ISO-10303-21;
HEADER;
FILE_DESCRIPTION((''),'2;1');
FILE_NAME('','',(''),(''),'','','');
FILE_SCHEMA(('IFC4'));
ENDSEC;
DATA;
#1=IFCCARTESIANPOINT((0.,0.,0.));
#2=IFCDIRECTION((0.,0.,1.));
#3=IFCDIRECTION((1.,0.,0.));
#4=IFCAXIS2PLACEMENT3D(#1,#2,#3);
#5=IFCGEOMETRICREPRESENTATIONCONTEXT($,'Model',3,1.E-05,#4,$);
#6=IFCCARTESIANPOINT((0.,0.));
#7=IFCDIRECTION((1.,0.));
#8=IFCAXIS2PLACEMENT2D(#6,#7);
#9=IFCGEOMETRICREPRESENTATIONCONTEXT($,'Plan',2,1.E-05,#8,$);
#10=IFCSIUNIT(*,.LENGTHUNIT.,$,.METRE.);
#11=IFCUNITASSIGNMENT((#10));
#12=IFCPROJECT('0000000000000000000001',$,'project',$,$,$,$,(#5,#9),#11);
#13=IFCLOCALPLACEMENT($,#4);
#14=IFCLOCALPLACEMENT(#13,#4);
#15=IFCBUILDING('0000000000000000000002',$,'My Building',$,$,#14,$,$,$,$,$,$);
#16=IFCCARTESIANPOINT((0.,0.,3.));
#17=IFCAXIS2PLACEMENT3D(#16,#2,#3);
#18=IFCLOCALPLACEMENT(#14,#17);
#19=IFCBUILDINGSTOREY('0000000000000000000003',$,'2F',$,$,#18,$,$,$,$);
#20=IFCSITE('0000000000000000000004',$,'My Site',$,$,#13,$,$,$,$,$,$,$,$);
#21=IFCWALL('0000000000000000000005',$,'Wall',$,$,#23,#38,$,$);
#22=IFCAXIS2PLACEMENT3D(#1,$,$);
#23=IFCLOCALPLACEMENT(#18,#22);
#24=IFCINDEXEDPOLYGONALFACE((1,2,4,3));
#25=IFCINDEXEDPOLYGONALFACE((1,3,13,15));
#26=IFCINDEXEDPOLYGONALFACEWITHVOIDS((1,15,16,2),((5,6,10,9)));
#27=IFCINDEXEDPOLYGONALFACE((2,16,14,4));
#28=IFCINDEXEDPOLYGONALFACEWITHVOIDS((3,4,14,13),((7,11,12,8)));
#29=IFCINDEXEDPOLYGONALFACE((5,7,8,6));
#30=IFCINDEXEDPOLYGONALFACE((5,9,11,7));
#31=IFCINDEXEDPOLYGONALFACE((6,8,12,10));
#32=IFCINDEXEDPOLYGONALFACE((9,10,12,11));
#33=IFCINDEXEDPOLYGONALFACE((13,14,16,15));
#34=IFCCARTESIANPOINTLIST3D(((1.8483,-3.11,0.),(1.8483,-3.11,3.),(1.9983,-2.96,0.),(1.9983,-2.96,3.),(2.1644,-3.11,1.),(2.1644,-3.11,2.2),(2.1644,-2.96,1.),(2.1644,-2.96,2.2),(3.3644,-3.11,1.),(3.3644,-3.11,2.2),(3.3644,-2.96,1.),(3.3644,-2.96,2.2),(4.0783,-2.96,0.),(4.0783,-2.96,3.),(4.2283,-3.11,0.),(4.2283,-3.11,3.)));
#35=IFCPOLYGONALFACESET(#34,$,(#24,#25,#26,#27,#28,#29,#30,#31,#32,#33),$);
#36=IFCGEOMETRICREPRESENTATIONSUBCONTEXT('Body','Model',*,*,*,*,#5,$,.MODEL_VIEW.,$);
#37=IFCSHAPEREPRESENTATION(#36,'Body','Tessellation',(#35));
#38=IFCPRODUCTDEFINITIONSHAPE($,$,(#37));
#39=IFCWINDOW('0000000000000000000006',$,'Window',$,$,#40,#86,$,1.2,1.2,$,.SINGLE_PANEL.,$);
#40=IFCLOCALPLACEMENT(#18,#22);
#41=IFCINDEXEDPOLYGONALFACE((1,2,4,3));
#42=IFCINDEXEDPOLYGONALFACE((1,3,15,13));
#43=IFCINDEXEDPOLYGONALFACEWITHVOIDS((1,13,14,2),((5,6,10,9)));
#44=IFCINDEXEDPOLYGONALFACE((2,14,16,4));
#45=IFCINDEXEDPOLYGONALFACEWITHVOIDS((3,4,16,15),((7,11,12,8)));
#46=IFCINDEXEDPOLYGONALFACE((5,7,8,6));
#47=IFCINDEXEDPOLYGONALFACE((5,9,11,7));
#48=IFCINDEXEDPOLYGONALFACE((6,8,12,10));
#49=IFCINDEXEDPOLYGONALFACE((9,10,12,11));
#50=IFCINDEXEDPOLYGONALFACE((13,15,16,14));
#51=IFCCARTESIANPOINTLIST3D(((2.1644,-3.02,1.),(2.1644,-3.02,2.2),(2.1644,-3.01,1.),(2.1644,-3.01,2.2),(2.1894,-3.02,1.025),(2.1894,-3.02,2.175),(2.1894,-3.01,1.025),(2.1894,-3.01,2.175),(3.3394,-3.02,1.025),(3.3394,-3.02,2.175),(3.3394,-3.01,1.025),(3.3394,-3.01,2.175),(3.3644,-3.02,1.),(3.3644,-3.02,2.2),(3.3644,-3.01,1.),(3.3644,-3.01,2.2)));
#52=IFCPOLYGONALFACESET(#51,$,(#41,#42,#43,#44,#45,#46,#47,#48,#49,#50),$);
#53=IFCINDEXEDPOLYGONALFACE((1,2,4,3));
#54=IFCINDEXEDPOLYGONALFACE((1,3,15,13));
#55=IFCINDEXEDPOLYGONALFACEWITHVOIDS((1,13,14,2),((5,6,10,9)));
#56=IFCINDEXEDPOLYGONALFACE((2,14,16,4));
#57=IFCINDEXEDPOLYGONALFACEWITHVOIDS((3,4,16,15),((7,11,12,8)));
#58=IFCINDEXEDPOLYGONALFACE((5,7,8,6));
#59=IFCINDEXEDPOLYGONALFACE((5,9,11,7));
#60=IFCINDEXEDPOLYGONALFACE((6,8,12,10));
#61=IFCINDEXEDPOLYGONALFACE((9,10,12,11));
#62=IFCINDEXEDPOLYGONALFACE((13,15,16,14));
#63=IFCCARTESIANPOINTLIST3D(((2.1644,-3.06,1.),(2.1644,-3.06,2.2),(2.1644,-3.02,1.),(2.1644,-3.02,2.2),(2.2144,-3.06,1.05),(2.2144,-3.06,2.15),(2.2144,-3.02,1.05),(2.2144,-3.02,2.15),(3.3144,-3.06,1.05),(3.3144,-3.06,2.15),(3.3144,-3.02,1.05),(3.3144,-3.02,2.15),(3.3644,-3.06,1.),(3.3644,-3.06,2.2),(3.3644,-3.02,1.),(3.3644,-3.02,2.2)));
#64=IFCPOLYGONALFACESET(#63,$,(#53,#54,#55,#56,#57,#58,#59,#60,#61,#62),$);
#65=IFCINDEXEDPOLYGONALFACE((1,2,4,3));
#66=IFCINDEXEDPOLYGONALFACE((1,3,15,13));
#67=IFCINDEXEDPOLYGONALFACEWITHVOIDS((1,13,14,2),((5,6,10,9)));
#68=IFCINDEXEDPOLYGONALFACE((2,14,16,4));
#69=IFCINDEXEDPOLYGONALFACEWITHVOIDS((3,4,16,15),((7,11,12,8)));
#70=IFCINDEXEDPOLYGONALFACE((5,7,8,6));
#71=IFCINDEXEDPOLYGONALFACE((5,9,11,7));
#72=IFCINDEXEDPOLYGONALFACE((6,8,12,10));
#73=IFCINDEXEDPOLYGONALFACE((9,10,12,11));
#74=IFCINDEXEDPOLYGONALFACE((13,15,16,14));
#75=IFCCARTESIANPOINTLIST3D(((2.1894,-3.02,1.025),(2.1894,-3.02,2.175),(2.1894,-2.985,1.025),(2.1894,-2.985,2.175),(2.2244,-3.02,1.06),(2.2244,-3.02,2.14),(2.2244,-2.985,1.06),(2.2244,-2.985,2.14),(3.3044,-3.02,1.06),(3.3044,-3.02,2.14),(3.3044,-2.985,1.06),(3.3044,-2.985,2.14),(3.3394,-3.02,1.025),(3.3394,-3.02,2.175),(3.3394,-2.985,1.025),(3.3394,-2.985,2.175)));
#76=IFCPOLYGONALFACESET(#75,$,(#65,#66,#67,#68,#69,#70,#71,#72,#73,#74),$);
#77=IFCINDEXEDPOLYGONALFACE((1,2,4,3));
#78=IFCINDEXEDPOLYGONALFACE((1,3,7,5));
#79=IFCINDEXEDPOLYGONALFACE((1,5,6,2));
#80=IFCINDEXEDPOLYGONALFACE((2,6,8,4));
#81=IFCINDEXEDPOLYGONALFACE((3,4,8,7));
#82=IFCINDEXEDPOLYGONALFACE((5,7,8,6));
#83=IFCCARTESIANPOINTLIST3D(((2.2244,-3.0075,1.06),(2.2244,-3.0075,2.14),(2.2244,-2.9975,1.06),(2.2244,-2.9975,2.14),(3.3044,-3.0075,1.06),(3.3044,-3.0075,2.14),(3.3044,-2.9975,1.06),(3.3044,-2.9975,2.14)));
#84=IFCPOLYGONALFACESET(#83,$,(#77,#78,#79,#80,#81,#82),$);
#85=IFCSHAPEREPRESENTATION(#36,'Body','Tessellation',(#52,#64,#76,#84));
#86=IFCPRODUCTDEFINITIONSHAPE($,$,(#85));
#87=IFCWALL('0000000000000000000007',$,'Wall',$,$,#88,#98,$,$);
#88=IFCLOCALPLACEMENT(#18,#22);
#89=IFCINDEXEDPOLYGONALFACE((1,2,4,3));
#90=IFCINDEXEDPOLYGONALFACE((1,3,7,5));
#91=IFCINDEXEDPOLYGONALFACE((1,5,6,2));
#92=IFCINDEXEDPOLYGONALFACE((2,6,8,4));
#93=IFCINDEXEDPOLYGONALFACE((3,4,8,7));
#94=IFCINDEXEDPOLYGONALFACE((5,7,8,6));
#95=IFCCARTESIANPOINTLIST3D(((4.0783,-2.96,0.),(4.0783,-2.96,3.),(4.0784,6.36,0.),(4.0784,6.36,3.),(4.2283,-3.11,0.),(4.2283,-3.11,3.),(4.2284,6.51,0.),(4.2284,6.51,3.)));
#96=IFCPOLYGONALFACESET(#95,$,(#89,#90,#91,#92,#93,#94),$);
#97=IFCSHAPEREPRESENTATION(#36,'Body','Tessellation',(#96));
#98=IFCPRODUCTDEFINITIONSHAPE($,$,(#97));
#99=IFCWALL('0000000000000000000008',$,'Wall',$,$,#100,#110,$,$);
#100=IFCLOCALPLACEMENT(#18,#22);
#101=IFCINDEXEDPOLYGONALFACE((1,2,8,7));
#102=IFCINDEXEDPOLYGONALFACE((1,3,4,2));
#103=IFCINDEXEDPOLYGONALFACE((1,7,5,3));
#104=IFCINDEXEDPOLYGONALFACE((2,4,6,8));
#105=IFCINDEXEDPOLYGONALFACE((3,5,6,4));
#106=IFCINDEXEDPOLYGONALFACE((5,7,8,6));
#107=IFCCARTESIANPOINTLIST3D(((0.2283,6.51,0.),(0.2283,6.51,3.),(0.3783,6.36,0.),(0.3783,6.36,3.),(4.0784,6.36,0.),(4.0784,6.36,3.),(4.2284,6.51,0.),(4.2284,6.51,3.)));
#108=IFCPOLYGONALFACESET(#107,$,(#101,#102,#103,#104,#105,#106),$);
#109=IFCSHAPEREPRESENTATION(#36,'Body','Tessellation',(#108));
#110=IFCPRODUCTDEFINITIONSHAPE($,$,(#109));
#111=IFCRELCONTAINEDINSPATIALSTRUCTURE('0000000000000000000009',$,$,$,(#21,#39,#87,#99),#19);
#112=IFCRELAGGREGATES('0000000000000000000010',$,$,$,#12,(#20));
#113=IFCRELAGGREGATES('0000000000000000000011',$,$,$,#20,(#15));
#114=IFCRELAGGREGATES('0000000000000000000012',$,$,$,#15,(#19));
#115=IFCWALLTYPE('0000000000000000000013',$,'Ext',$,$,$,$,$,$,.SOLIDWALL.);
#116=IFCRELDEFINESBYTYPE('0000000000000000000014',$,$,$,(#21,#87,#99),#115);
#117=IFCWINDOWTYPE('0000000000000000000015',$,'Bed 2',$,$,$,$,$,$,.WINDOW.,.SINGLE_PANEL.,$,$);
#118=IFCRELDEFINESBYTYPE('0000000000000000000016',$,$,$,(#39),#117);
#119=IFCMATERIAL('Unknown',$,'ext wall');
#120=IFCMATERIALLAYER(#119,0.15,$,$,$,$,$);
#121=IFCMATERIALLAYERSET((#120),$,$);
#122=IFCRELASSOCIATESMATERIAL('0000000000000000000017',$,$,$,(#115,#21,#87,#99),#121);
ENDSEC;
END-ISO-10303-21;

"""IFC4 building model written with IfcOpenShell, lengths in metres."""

from ifc_helpers import new_model, entity, si_unit, frame, origin_with_axes, origin_2d_with_axis, place, context, subcontext, project, spatial, line, indexed_curve, outline, extrude, shape, source, transform, mapped, material, layer, layer_set, layer_usage, type_object, type_shapes, element, fill, save


model = new_model("IFC4")

# Units and contexts
model_context = context("Model", 3, precision=1e-05, world=origin_with_axes())
plan_context = context("Plan", 2, precision=1e-05, world=origin_2d_with_axis())
body_context_1 = subcontext(model_context, "Body", "Model", "MODEL_VIEW")
body_context_2 = subcontext(plan_context, "Body", "Plan", "PLAN_VIEW")
ifc_project = project(units=[si_unit("LENGTHUNIT", "METRE")], contexts=[model_context, plan_context])

# Site, building, storey
site_placement = place(None, origin_with_axes())
site = spatial("IfcSite", under=ifc_project, at=site_placement, Name="My Site")
building_placement = place(site_placement, origin_with_axes())
building = spatial("IfcBuilding", under=site, at=building_placement, Name="My Building")
storey_placement = place(building_placement, frame((0.0, 0.0, 3.0), z_axis=(0.0, 0.0, 1.0), x_axis=(1.0, 0.0, 0.0)))
storey = spatial("IfcBuildingStorey", under=building, at=storey_placement, Name="2F")

# Shared definitions
ifc_material = material(Name="Unknown", Category="ext wall")
ifc_layer_1 = layer(ifc_material, 0.15)
ifc_layer_set_1 = layer_set([ifc_layer_1])
wall_type_1 = type_object("IfcWallType", Name="Ext", PredefinedType="SOLIDWALL", material=ifc_layer_set_1)

# Wall, opening, window
ifc_layer_usage_1 = layer_usage(ifc_layer_set_1, "AXIS2", "POSITIVE", 0.0)
wall_1_placement = place(storey_placement, frame((1.8483, -3.11, 0.0), z_axis=(0.0, 0.0, 1.0), x_axis=(1.0, 0.0, 0.0)))
wall_1 = element("IfcWall", 1, at=wall_1_placement, inside=storey, type_object=wall_type_1, material=ifc_layer_usage_1, Name="Wall", context=body_context_1, shape_type="SweptSolid", body=[
    extrude(outline(indexed_curve([(0.0, 0.0), (0.15, 0.15), (2.23, 0.15), (2.38, 0.0)], segments=[line(1, 2, 3, 4, 1)])), origin_with_axes(), (0.0, 0.0, 1.0), 3.0),
])
shared_shape_1 = source(origin_with_axes(), body_context_1, "Body", "SweptSolid", [
    extrude(outline(indexed_curve([(0.0, 0.0), (1.2, 0.0), (1.2, 1.2), (0.0, 1.2)], segments=[line(1, 2, 3, 4, 1)])), frame((0.0, -0.6, 0.0), z_axis=(0.0, -1.0, 0.0), x_axis=(1.0, 0.0, 0.0)), (0.0, 0.0, -1.0), 1.2),
])
opening_1_placement = place(wall_1_placement, frame((0.316, 0.0, 1.0), z_axis=(0.0, 0.0, 1.0), x_axis=(1.0, 0.0, 0.0)))
opening_1 = element("IfcOpeningElement", 2, at=opening_1_placement, cuts=wall_1, PredefinedType="OPENING", context=body_context_1, shape_type="MappedRepresentation", body=[
    mapped(shared_shape_1, transform((0.0, 0.0, 0.0), x_axis=(1.0, 0.0, 0.0), y_axis=(0.0, 1.0, 0.0), z_axis=(0.0, 0.0, 1.0), scale=1.0)),
])
window_type_1 = type_object("IfcWindowType", Name="Bed 2", PartitioningType="SINGLE_PANEL", PredefinedType="WINDOW")
shared_shape_2 = source(origin_with_axes(), body_context_1, "Body", "SweptSolid", [
    extrude(outline(indexed_curve([(0.0, 0.0), (1.2, 0.0), (1.2, 1.2), (0.0, 1.2)], segments=[line(1, 2, 3, 4, 1)]), holes=[indexed_curve([(0.025, 0.025), (1.175, 0.025), (1.175, 1.175), (0.025, 1.175)], segments=[line(1, 2, 3, 4, 1)])]), frame((0.0, 0.09, 0.0), z_axis=(0.0, -1.0, 0.0), x_axis=(1.0, 0.0, 0.0)), (0.0, 0.0, -1.0), 0.01),
    extrude(outline(indexed_curve([(0.0, 0.0), (1.2, 0.0), (1.2, 1.2), (0.0, 1.2)], segments=[line(1, 2, 3, 4, 1)]), holes=[indexed_curve([(0.05, 0.05), (1.15, 0.05), (1.15, 1.15), (0.05, 1.15)], segments=[line(1, 2, 3, 4, 1)])]), frame((0.0, 0.05, 0.0), z_axis=(0.0, -1.0, 0.0), x_axis=(1.0, 0.0, 0.0)), (0.0, 0.0, -1.0), 0.04),
    extrude(outline(indexed_curve([(0.0, 0.0), (1.15, 0.0), (1.15, 1.15), (0.0, 1.15)], segments=[line(1, 2, 3, 4, 1)]), holes=[indexed_curve([(0.035, 0.035), (1.115, 0.035), (1.115, 1.115), (0.035, 1.115)], segments=[line(1, 2, 3, 4, 1)])]), frame((0.025, 0.09, 0.025), z_axis=(0.0, -1.0, 0.0), x_axis=(1.0, 0.0, 0.0)), (0.0, 0.0, -1.0), 0.035),
    extrude(outline(indexed_curve([(0.035, 0.035), (1.115, 0.035), (1.115, 1.115), (0.035, 1.115)], segments=[line(1, 2, 3, 4, 1)])), frame((0.025, 0.1025, 0.025), z_axis=(0.0, -1.0, 0.0), x_axis=(1.0, 0.0, 0.0)), (0.0, 0.0, -1.0), 0.01),
])
shared_shape_3 = source(origin_with_axes(), body_context_2, "Body", "Curve2D", [
    entity("IfcIndexedPolyCurve", entity("IfcCartesianPointList2D", [[0.05, 0.05], [1.15, 0.05]])),
    entity("IfcIndexedPolyCurve", entity("IfcCartesianPointList2D", [[0.0, 0.1], [0.025, 0.1], [0.025, 0.09], [0.05, 0.09], [0.05, 0.05], [0.0, 0.05]]), [entity("IfcLineIndex", [1, 2, 3, 4, 5, 6, 1])]),
    entity("IfcIndexedPolyCurve", entity("IfcCartesianPointList2D", [[1.2, 0.1], [1.175, 0.1], [1.175, 0.09], [1.15, 0.09], [1.15, 0.05], [1.2, 0.05]]), [entity("IfcLineIndex", [1, 2, 3, 4, 5, 6, 1])]),
    entity("IfcIndexedPolyCurve", entity("IfcCartesianPointList2D", [[0.025, 0.09], [0.06, 0.09], [0.06, 0.125], [0.025, 0.125]]), [entity("IfcLineIndex", [1, 2, 3, 4, 1])]),
    entity("IfcIndexedPolyCurve", entity("IfcCartesianPointList2D", [[1.175, 0.09], [1.14, 0.09], [1.14, 0.125], [1.175, 0.125]]), [entity("IfcLineIndex", [1, 2, 3, 4, 1])]),
    entity("IfcIndexedPolyCurve", entity("IfcCartesianPointList2D", [[0.06, 0.09], [1.14, 0.09]])),
    entity("IfcIndexedPolyCurve", entity("IfcCartesianPointList2D", [[0.06, 0.125], [1.14, 0.125]])),
    entity("IfcIndexedPolyCurve", entity("IfcCartesianPointList2D", [[0.06, 0.1075], [1.14, 0.1075]])),
])
type_shapes(window_type_1, [shared_shape_2, shared_shape_3])
window_1_placement = place(opening_1_placement, frame((0.0, 0.0, 0.0), z_axis=(0.0, 0.0, 1.0), x_axis=(1.0, 0.0, 0.0)))
window_1 = element("IfcWindow", 3, at=window_1_placement, inside=storey, type_object=window_type_1, Name="Window", OverallHeight=1.2, OverallWidth=1.2, PartitioningType="SINGLE_PANEL", shapes=[
    shape(body_context_1, "Body", "MappedRepresentation", [mapped(shared_shape_2, transform((0.0, 0.0, 0.0), x_axis=(1.0, 0.0, 0.0), y_axis=(0.0, 1.0, 0.0), z_axis=(0.0, 0.0, 1.0), scale=1.0))]),
    shape(body_context_2, "Body", "MappedRepresentation", [mapped(shared_shape_3, transform((0.0, 0.0, 0.0), x_axis=(1.0, 0.0, 0.0), y_axis=(0.0, 1.0, 0.0), z_axis=(0.0, 0.0, 1.0), scale=1.0))]),
])
fill(opening_1, window_1)

# Walls
ifc_layer_usage_2 = layer_usage(ifc_layer_set_1, "AXIS2", "POSITIVE", 0.0)
wall_2_placement = place(storey_placement, frame((4.2283, -3.11, 0.0), z_axis=(0.0, 0.0, 1.0), x_axis=(0.0, 1.0, 0.0)))
element("IfcWall", 4, at=wall_2_placement, inside=storey, type_object=wall_type_1, material=ifc_layer_usage_2, Name="Wall", context=body_context_1, shape_type="SweptSolid", body=[
    extrude(outline(indexed_curve([(0.0, 0.0), (0.15, 0.15), (9.47, 0.15), (9.62, 0.0)], segments=[line(1, 2, 3, 4, 1)])), origin_with_axes(), (0.0, 0.0, 1.0), 3.0),
])
ifc_layer_usage_3 = layer_usage(ifc_layer_set_1, "AXIS2", "POSITIVE", 0.0)
wall_3_placement = place(storey_placement, frame((4.2284, 6.51, 0.0), z_axis=(0.0, 0.0, 1.0), x_axis=(-1.0, 0.0, 0.0)))
element("IfcWall", 5, at=wall_3_placement, inside=storey, type_object=wall_type_1, material=ifc_layer_usage_3, Name="Wall", context=body_context_1, shape_type="SweptSolid", body=[
    extrude(outline(indexed_curve([(0.0, 0.0), (0.15, 0.15), (3.85, 0.15), (4.0, 0.0)], segments=[line(1, 2, 3, 4, 1)])), origin_with_axes(), (0.0, 0.0, 1.0), 3.0),
])

save(model, "model.ifc")
